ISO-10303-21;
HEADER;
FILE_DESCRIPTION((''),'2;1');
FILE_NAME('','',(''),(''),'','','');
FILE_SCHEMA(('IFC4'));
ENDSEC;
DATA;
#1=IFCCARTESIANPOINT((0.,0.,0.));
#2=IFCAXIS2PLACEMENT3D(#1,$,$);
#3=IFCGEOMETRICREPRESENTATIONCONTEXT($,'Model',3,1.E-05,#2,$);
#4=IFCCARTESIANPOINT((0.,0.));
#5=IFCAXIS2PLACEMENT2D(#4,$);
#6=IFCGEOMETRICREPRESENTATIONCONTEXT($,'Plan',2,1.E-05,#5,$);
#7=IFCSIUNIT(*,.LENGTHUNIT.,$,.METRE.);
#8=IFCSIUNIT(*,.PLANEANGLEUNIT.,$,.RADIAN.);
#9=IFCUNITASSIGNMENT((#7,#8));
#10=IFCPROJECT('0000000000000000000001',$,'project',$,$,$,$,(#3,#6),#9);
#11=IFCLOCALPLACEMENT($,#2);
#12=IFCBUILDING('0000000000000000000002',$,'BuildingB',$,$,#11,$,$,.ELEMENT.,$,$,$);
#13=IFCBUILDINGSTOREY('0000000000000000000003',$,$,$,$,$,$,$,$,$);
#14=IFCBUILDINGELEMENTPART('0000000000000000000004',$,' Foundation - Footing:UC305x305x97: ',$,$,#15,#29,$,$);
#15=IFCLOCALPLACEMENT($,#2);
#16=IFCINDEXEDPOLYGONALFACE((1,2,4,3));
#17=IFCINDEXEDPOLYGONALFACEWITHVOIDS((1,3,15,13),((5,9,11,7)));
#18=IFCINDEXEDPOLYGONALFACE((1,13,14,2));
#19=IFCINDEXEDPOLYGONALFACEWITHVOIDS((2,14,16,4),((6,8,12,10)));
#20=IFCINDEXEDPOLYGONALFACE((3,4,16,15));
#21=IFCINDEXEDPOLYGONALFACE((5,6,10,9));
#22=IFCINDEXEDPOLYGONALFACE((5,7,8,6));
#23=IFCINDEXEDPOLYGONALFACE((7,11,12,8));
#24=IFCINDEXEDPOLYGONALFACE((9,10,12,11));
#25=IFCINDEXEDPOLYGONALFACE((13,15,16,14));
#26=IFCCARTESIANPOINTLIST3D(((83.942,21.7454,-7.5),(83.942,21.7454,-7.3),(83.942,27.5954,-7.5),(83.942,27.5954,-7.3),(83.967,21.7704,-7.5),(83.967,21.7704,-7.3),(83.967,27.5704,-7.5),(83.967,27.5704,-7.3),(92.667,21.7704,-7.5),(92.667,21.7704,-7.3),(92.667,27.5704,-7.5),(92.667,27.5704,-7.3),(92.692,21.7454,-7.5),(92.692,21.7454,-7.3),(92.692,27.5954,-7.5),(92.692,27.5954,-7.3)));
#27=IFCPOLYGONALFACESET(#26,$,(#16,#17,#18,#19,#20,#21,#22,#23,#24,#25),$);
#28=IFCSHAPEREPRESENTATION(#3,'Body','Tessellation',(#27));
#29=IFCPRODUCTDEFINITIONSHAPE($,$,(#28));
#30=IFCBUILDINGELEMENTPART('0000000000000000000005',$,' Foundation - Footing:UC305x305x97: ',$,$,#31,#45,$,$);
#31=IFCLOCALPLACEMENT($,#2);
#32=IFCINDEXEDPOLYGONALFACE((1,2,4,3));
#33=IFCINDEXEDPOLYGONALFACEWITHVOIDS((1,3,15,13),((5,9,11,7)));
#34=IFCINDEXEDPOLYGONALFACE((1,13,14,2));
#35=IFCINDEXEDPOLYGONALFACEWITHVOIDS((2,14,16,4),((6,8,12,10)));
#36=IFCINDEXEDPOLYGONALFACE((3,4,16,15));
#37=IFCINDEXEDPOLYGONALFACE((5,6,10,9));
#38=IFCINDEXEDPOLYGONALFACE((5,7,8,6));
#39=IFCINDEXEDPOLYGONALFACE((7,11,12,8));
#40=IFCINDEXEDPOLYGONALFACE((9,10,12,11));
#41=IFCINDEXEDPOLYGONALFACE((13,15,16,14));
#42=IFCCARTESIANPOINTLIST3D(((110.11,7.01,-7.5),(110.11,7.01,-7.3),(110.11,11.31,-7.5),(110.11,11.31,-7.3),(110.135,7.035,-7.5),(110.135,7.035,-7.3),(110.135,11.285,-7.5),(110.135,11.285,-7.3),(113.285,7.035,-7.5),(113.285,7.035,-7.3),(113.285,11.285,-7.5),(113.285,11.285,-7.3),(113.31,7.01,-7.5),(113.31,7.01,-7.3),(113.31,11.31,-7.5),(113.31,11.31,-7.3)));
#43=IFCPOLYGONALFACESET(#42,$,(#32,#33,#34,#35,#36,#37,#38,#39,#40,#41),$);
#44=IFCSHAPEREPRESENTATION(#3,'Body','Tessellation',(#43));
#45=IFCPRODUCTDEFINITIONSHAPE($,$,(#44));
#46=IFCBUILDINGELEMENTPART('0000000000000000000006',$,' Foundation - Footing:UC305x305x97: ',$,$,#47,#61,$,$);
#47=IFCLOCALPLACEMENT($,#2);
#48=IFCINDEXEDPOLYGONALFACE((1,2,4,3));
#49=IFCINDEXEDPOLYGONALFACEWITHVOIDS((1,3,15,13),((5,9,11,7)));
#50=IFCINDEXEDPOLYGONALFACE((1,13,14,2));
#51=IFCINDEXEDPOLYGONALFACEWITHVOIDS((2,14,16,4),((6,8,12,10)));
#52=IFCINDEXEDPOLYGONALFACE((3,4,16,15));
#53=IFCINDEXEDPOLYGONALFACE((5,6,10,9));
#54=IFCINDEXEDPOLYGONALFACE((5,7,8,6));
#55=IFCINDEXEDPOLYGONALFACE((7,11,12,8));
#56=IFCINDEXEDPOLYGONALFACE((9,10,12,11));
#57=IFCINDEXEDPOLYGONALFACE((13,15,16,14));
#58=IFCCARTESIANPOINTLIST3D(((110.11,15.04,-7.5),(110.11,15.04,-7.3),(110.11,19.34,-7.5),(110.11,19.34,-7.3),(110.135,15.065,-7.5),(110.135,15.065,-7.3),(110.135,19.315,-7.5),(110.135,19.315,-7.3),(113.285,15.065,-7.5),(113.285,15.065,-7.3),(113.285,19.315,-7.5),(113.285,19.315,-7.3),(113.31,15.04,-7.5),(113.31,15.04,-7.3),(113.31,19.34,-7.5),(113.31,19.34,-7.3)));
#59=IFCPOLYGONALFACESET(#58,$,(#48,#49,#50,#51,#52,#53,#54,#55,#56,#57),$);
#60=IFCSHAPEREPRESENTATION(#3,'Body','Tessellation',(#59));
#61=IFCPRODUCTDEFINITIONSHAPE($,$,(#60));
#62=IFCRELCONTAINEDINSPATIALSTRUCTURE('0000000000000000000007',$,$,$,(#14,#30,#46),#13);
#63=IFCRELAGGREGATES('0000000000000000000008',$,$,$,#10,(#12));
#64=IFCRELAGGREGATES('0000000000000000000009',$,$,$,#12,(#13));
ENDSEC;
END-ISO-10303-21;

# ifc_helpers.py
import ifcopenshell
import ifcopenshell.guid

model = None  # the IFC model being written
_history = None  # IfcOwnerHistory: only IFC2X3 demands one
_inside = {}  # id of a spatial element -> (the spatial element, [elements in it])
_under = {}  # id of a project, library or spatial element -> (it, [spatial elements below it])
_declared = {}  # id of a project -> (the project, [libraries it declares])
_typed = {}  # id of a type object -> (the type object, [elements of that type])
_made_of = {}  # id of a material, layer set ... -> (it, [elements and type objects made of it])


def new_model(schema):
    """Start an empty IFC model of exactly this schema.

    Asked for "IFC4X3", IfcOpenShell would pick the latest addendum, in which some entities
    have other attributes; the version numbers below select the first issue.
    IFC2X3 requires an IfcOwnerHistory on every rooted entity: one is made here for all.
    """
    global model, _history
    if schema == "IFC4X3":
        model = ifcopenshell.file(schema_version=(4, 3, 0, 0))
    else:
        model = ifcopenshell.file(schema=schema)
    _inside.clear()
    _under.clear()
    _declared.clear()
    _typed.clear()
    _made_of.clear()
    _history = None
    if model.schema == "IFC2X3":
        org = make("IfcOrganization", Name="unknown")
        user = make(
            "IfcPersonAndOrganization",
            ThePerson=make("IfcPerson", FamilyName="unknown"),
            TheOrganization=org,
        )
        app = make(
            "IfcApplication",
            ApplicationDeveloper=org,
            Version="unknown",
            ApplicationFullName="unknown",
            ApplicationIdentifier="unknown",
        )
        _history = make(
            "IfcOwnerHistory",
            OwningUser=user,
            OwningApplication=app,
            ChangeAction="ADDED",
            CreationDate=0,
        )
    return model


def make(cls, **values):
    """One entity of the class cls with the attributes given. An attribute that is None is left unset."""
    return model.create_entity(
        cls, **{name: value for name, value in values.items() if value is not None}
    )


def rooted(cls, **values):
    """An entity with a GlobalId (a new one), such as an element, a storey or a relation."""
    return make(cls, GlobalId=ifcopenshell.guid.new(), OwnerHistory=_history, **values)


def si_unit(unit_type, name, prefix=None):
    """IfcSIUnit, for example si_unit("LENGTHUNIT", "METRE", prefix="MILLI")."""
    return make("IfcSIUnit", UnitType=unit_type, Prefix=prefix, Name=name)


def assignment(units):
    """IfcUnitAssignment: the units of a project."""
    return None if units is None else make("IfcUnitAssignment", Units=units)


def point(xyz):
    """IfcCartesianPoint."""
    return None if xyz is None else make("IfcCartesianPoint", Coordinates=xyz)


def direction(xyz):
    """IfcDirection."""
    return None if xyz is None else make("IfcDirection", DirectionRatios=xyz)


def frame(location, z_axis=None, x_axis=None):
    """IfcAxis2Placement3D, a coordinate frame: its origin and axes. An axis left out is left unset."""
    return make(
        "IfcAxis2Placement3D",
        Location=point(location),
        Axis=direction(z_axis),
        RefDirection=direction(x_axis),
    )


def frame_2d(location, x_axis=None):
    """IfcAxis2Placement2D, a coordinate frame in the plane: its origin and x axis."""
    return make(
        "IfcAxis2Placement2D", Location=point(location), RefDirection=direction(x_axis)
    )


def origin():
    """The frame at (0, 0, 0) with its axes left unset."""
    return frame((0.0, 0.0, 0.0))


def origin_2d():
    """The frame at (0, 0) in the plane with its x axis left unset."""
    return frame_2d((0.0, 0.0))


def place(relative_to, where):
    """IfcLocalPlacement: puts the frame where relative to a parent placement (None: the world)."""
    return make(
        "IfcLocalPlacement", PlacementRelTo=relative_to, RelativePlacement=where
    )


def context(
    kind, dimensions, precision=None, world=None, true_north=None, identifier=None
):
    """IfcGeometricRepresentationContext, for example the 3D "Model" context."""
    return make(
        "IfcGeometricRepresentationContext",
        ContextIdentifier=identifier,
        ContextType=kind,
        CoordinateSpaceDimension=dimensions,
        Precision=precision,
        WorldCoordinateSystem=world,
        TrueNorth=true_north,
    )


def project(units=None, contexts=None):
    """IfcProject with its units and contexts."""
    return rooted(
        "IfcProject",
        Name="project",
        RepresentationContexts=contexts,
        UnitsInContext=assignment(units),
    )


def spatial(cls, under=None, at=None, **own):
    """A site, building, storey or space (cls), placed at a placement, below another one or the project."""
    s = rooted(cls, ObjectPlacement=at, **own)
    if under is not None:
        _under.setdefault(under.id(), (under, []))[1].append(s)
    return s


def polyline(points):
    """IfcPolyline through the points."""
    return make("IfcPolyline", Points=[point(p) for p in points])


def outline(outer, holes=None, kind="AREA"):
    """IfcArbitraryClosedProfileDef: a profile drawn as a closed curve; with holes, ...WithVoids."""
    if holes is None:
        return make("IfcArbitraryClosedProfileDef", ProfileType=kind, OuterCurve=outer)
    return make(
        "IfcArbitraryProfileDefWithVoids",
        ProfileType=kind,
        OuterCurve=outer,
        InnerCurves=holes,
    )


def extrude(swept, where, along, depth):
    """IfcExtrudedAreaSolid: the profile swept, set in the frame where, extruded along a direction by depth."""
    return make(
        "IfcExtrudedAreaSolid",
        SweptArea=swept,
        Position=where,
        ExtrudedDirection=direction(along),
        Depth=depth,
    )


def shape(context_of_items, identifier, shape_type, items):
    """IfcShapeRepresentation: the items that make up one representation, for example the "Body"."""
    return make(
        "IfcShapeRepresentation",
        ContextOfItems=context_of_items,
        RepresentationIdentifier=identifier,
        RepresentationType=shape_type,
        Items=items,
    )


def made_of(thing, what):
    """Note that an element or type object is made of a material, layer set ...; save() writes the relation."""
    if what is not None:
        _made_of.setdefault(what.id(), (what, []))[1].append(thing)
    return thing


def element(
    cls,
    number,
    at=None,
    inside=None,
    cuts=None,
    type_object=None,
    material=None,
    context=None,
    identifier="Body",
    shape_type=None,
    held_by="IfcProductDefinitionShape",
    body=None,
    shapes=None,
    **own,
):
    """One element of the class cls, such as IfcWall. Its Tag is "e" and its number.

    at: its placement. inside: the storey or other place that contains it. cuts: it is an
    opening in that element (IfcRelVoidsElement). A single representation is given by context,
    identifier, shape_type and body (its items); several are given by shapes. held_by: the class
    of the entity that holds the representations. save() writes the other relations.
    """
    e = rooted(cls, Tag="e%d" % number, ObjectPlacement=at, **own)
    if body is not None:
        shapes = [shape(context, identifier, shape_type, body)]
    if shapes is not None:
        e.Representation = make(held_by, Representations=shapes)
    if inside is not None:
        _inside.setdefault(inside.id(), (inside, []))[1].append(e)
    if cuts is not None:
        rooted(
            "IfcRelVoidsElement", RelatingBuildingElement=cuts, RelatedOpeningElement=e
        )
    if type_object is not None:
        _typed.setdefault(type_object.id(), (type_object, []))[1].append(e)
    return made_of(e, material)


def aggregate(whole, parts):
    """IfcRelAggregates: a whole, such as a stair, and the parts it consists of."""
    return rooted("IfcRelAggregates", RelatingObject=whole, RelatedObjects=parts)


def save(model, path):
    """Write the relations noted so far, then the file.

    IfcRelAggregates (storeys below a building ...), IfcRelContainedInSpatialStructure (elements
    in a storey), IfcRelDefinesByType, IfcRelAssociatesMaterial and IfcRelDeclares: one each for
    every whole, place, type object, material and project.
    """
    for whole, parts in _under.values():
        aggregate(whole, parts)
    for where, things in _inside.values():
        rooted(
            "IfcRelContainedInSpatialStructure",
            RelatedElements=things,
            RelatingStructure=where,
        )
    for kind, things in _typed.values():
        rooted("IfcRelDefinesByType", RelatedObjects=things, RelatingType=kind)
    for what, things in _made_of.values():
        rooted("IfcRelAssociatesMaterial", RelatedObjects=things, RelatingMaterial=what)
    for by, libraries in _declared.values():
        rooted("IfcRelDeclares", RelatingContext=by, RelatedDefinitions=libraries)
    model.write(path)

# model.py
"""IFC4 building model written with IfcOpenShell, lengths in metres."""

from ifc_helpers import new_model, si_unit, origin, origin_2d, place, context, project, spatial, polyline, outline, extrude, element, save


model = new_model("IFC4")

# Units and contexts
model_context = context("Model", 3, precision=1e-05, world=origin())
plan_context = context("Plan", 2, precision=1e-05, world=origin_2d())
ifc_project = project(units=[si_unit("LENGTHUNIT", "METRE"), si_unit("PLANEANGLEUNIT", "RADIAN")], contexts=[model_context, plan_context])

# Building, storey
building_placement = place(None, origin())
building = spatial("IfcBuilding", under=ifc_project, at=building_placement, Name="BuildingB", CompositionType="ELEMENT")
storey = spatial("IfcBuildingStorey", under=building)

# Building element parts, openings
building_element_part_1 = element("IfcBuildingElementPart", 1, inside=storey, Name=" Foundation - Footing:UC305x305x97: ", context=model_context, shape_type="SweptSolid", body=[
    extrude(outline(polyline([(83.942, 21.7454, -7.5), (92.692, 21.7454, -7.5), (92.692, 27.5954, -7.5), (83.942, 27.5954, -7.5), (83.942, 21.7454, -7.5)])), None, (0.0, 0.0, 1.0), 0.2),
])
element("IfcOpeningElement", 2, inside=storey, cuts=building_element_part_1, context=model_context, shape_type="SweptSolid", body=[
    extrude(outline(polyline([(83.967, 21.7704, -7.5), (92.667, 21.7704, -7.5), (92.667, 27.5704, -7.5), (83.967, 27.5704, -7.5), (83.967, 21.7704, -7.5)])), None, (0.0, 0.0, 1.0), 0.2),
])
building_element_part_2 = element("IfcBuildingElementPart", 3, inside=storey, Name=" Foundation - Footing:UC305x305x97: ", context=model_context, shape_type="SweptSolid", body=[
    extrude(outline(polyline([(110.11, 11.31, -7.5), (113.31, 11.31, -7.5), (113.31, 7.01, -7.5), (110.11, 7.01, -7.5), (110.11, 11.31, -7.5)])), None, (0.0, 0.0, 1.0), 0.2),
])
element("IfcOpeningElement", 4, inside=storey, cuts=building_element_part_2, context=model_context, shape_type="SweptSolid", body=[
    extrude(outline(polyline([(110.135, 11.285, -7.5), (113.285, 11.285, -7.5), (113.285, 7.035, -7.5), (110.135, 7.035, -7.5), (110.135, 11.285, -7.5)])), None, (0.0, 0.0, 1.0), 0.2),
])
building_element_part_3 = element("IfcBuildingElementPart", 5, inside=storey, Name=" Foundation - Footing:UC305x305x97: ", context=model_context, shape_type="SweptSolid", body=[
    extrude(outline(polyline([(110.11, 19.34, -7.5), (113.31, 19.34, -7.5), (113.31, 15.04, -7.5), (110.11, 15.04, -7.5), (110.11, 19.34, -7.5)])), None, (0.0, 0.0, 1.0), 0.2),
])
element("IfcOpeningElement", 6, inside=storey, cuts=building_element_part_3, context=model_context, shape_type="SweptSolid", body=[
    extrude(outline(polyline([(110.135, 19.315, -7.5), (113.285, 19.315, -7.5), (113.285, 15.065, -7.5), (110.135, 15.065, -7.5), (110.135, 19.315, -7.5)])), None, (0.0, 0.0, 1.0), 0.2),
])

save(model, "model.ifc")
